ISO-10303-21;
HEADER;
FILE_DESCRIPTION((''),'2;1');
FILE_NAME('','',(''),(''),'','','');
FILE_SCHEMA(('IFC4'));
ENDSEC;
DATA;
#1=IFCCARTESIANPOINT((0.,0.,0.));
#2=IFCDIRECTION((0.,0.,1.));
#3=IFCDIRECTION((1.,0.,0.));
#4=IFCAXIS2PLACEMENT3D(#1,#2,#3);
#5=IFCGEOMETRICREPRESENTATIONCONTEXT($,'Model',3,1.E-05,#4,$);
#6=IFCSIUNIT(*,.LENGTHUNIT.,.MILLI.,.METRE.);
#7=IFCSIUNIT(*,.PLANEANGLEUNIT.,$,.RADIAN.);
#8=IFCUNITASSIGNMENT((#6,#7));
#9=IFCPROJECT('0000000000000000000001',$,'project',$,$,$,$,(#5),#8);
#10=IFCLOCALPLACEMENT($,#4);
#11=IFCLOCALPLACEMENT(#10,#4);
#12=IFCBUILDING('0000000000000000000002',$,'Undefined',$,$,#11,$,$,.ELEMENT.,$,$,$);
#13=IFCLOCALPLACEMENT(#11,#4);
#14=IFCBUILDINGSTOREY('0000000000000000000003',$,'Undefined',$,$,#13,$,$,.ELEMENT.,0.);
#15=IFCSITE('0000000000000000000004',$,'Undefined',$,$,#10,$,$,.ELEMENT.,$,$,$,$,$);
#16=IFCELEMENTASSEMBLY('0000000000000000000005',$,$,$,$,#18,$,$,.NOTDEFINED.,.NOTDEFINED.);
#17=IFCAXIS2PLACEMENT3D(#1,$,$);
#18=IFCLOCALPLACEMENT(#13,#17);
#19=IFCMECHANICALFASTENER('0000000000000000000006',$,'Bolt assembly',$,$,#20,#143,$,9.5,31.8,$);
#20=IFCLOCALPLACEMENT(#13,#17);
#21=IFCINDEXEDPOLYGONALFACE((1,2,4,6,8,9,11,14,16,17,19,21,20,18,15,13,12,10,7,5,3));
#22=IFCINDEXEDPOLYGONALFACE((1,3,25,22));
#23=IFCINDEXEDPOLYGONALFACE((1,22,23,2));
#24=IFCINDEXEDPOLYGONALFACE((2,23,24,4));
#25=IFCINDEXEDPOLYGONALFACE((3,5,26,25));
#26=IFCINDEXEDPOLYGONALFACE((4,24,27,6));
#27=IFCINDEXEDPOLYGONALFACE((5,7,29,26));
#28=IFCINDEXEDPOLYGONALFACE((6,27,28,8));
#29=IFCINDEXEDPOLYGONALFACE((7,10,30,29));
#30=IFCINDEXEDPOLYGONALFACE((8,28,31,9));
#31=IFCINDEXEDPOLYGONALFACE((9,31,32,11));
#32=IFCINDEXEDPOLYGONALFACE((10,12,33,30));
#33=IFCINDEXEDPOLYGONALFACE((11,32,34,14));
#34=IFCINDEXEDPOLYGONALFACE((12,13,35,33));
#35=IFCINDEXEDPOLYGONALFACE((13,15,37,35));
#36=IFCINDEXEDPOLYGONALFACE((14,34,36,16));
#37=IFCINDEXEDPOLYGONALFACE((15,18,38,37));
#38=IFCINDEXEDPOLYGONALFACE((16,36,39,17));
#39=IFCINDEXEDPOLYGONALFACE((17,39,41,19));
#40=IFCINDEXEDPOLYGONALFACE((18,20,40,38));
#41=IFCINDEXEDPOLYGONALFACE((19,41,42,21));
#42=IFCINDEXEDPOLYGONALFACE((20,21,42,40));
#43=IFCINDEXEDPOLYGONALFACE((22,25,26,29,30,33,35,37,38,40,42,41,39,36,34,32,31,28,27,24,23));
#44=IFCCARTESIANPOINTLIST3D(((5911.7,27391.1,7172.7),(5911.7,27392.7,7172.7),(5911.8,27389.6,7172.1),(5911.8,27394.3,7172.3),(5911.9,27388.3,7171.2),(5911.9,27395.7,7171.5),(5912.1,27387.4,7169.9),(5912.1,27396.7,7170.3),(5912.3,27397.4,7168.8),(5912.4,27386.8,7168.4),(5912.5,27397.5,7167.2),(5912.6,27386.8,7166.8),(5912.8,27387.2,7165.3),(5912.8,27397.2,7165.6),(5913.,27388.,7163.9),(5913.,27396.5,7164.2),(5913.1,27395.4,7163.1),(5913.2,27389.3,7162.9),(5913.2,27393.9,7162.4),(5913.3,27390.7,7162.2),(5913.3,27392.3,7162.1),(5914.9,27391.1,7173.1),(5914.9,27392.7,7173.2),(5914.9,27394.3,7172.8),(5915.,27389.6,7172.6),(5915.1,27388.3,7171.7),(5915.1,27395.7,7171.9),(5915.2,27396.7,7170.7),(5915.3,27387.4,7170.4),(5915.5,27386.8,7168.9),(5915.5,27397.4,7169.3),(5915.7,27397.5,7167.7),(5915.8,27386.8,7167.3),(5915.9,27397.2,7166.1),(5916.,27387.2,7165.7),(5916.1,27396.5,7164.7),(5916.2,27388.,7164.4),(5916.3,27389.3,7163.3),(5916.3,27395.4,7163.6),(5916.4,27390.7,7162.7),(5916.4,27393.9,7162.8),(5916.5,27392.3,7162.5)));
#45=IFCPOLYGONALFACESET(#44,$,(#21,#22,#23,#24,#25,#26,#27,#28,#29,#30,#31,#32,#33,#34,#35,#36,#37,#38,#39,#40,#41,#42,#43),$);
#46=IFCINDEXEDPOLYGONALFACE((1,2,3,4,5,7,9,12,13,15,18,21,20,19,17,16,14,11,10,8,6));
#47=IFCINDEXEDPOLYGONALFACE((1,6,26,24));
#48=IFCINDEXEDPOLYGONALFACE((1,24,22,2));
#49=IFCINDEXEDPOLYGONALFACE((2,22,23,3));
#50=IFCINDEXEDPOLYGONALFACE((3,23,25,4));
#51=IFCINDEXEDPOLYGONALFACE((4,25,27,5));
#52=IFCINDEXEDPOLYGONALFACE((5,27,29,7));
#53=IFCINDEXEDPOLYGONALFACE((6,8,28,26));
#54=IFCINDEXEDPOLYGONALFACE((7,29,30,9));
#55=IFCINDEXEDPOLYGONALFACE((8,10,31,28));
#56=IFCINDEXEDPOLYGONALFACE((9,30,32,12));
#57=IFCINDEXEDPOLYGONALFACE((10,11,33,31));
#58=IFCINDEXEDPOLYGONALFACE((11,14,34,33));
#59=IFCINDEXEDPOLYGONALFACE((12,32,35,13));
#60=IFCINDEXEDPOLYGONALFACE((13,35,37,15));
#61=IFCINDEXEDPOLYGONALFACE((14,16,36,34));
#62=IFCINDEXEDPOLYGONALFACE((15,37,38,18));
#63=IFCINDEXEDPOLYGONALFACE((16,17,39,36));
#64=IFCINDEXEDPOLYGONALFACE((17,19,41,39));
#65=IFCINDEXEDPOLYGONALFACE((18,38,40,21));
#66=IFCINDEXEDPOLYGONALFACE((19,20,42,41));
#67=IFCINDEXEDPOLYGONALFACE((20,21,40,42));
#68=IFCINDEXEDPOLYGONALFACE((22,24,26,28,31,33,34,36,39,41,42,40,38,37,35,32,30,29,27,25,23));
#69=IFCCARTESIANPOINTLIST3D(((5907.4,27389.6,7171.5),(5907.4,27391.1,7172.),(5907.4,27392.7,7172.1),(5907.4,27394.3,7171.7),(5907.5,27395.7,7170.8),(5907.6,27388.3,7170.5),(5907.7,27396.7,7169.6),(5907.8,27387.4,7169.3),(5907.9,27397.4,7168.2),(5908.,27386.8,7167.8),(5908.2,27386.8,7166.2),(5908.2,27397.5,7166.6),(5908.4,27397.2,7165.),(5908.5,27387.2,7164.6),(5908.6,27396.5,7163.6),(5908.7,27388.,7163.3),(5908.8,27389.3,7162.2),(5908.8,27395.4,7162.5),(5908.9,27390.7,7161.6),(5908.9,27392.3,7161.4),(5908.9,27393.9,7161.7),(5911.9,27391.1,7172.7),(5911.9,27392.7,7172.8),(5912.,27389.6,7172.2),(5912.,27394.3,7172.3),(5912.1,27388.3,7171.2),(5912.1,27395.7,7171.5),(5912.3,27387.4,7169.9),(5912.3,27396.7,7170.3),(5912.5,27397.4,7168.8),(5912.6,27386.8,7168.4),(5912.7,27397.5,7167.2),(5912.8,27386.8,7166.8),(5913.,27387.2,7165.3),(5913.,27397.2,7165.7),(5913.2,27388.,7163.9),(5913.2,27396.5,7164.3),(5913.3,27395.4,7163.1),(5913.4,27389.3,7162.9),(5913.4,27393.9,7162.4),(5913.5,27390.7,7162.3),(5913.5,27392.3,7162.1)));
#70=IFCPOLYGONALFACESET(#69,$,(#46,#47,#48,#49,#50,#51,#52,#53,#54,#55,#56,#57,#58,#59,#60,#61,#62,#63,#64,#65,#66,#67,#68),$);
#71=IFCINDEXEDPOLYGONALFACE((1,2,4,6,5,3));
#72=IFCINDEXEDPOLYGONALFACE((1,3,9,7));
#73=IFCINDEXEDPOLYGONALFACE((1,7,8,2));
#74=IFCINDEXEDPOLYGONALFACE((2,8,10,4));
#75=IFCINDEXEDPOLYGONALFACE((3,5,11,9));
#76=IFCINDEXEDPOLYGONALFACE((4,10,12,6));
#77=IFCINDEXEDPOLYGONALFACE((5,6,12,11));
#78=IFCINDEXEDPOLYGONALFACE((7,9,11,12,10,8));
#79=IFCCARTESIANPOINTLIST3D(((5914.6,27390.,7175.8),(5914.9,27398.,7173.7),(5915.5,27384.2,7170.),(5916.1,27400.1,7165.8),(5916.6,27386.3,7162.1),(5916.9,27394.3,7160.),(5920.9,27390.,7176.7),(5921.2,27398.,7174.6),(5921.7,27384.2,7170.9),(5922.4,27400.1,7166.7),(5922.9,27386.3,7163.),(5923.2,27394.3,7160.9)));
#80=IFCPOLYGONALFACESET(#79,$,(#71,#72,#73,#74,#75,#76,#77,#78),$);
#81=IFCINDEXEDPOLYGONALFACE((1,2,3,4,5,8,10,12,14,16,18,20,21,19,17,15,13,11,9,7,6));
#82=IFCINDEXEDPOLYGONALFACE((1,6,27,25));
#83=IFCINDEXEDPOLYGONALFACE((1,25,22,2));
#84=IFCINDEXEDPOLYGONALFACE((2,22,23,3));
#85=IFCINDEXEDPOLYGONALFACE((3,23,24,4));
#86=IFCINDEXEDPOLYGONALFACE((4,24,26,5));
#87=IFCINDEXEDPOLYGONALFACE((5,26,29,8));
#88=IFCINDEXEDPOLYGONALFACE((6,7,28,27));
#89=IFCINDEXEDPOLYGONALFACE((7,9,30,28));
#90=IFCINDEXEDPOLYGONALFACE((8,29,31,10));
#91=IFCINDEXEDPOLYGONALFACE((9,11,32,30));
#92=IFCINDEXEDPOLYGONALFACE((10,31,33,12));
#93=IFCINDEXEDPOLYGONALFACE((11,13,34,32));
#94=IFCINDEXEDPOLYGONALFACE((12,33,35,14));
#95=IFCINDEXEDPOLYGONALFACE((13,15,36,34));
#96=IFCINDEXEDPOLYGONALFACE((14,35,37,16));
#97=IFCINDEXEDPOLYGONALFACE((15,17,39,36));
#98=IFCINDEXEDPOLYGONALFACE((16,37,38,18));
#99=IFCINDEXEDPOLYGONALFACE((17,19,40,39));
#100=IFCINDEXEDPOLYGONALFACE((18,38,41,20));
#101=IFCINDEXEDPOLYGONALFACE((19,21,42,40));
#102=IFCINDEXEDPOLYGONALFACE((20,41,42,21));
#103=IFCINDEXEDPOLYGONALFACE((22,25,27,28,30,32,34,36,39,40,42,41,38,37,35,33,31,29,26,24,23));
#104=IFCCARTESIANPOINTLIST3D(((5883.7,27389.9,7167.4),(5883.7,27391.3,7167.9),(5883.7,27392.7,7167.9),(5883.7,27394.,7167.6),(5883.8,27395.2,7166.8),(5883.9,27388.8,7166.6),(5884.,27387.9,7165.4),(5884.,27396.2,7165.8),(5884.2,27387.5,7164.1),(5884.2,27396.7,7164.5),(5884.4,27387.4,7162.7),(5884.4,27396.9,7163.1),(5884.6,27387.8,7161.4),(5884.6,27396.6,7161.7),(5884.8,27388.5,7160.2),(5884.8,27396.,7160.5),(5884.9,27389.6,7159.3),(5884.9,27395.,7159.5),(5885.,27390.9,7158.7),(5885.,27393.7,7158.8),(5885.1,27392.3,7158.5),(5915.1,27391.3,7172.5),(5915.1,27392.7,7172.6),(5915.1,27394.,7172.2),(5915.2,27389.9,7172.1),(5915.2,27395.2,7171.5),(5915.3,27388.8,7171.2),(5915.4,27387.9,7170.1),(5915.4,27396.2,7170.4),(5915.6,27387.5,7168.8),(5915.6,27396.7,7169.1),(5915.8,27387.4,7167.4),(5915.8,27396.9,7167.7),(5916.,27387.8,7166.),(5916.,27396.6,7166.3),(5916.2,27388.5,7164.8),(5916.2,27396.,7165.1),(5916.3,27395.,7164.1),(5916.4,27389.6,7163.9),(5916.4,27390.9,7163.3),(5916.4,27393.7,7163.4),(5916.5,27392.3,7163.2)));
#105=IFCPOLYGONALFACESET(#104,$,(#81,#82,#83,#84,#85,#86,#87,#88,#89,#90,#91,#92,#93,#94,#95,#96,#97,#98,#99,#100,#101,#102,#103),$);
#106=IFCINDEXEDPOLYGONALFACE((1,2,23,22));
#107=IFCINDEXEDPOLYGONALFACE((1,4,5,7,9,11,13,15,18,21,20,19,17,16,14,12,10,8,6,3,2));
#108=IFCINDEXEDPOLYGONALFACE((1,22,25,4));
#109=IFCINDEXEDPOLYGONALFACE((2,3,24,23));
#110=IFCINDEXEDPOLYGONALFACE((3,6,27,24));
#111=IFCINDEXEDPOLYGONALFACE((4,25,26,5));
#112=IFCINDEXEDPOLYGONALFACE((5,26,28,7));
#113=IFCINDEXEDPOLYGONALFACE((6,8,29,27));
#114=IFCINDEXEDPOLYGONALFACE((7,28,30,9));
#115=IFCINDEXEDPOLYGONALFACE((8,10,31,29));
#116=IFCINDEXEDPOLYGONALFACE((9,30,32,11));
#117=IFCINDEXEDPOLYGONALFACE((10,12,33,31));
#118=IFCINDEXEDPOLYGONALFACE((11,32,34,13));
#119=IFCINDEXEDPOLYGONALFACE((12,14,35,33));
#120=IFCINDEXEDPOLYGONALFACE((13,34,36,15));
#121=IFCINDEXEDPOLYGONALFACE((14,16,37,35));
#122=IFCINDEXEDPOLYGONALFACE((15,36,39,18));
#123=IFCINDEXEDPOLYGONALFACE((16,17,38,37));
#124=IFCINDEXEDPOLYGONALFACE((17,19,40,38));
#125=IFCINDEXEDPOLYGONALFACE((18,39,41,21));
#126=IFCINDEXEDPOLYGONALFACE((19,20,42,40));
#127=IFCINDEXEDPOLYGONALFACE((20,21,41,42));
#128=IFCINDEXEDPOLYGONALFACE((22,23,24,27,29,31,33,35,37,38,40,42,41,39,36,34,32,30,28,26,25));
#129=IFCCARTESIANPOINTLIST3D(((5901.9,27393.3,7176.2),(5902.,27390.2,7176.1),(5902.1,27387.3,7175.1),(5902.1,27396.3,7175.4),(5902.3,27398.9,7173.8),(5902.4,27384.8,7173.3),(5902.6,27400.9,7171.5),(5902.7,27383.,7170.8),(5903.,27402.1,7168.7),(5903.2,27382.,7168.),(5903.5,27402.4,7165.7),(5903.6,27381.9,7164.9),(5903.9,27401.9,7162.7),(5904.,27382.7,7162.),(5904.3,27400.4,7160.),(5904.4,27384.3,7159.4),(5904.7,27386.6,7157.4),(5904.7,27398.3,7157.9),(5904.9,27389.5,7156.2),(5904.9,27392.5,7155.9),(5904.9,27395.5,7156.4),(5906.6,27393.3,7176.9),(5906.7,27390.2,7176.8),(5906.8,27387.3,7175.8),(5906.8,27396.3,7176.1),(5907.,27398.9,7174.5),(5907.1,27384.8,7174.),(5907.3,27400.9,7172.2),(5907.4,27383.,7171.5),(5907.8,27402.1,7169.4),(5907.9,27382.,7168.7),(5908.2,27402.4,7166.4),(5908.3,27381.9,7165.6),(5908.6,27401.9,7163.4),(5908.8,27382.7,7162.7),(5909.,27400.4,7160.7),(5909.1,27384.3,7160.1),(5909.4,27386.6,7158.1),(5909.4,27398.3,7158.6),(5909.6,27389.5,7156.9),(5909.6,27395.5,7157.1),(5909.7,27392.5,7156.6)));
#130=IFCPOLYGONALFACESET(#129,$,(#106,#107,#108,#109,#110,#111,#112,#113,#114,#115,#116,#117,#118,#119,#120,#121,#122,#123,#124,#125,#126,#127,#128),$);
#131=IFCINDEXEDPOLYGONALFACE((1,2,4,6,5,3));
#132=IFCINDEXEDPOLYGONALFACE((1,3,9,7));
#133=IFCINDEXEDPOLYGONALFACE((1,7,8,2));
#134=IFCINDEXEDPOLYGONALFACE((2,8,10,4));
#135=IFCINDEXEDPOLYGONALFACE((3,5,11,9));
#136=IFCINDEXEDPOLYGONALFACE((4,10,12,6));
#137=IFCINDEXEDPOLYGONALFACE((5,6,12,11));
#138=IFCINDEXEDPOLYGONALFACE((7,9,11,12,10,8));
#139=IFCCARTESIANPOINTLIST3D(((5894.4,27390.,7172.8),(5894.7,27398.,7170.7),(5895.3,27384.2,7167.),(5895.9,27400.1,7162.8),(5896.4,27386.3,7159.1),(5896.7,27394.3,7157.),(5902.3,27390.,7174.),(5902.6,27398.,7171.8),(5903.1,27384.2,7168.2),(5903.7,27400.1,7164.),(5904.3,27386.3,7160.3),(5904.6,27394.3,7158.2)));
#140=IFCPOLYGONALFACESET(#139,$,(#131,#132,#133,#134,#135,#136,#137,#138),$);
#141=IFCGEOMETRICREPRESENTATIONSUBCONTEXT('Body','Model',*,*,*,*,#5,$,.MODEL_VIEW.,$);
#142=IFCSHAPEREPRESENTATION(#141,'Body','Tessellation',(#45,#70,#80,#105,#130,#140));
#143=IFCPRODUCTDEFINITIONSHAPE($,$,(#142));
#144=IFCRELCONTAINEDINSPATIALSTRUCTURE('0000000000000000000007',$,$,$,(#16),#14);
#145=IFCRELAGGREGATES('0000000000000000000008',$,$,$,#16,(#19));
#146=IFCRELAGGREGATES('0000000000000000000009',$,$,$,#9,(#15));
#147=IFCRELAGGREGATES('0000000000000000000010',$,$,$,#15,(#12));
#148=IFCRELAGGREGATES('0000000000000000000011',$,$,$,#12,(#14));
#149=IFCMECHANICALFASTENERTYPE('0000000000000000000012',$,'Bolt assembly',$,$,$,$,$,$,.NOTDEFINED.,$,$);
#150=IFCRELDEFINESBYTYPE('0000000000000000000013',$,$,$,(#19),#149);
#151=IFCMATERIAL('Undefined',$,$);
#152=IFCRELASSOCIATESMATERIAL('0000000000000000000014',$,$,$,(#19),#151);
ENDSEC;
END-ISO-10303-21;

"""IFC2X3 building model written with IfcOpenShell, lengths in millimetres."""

from ifc_helpers import new_model, si_unit, frame, origin_with_axes, origin_2d_with_axis, place, context, subcontext, project, spatial, polyline, circle, outline, extrude, source, transform, mapped, material, type_object, element, aggregate, save


model = new_model("IFC2X3")

# Units and contexts
model_context = context("Model", 3, precision=1e-05, world=origin_with_axes())
body_context = subcontext(model_context, "Body", "Model", "MODEL_VIEW")
ifc_project = project(units=[si_unit("LENGTHUNIT", "METRE", prefix="MILLI"), si_unit("PLANEANGLEUNIT", "RADIAN")], contexts=[model_context])

# Site, building, storey
site_placement = place(None, origin_with_axes())
site = spatial("IfcSite", under=ifc_project, at=site_placement, Name="Undefined", CompositionType="ELEMENT")
building_placement = place(site_placement, origin_with_axes())
building = spatial("IfcBuilding", under=site, at=building_placement, Name="Undefined", CompositionType="ELEMENT")
storey_placement = place(building_placement, origin_with_axes())
storey = spatial("IfcBuildingStorey", under=building, at=storey_placement, Name="Undefined", CompositionType="ELEMENT", Elevation=0.0)

# Element assembly
assembly_1_placement = place(storey_placement, origin_with_axes())
assembly_1 = element("IfcElementAssembly", 1, at=assembly_1_placement, inside=storey, AssemblyPlace="NOTDEFINED", PredefinedType="NOTDEFINED")

# Shared definitions
ifc_material_1 = material(Name="Undefined")
mechanical_fastener_type = type_object("IfcMechanicalFastenerType", Name="Bolt assembly")

# Mechanical fastener
shared_shape_1 = source(origin_with_axes(), body_context, "Body", "SweptSolid", [
    extrude(circle(Radius=5.4, at=origin_2d_with_axis()), frame((0.0, -3.1, 0.0), z_axis=(0.0, 1.0, 0.0), x_axis=(1.0, 0.0, 0.0)), (0.0, 0.0, 1.0), 3.2),
    extrude(circle(Radius=5.4, at=origin_2d_with_axis()), frame((0.0, -0.1, 0.0), z_axis=(0.0, 1.0, 0.0), x_axis=(1.0, 0.0, 0.0)), (0.0, 0.0, 1.0), 4.6),
    extrude(outline(polyline([(7.1, -4.1), (7.1, 4.1), (0.0, 8.2), (-7.1, 4.1), (-7.1, -4.1), (0.0, -8.2), (7.1, -4.1)])), frame((0.0, -9.6, 0.0), z_axis=(0.0, 1.0, 0.0), x_axis=(1.0, 0.0, 0.0)), (0.0, 0.0, 1.0), 6.3),
    extrude(circle(Radius=4.8, at=origin_2d_with_axis()), frame((0.0, -3.2, 0.0), z_axis=(0.0, 1.0, 0.0), x_axis=(1.0, 0.0, 0.0)), (0.0, 0.0, 1.0), 31.8),
    extrude(circle(Radius=10.3, at=origin_2d_with_axis()), frame((0.0, 4.5, 0.0), z_axis=(0.0, 1.0, 0.0), x_axis=(1.0, 0.0, 0.0)), (0.0, 0.0, 1.0), 4.8),
    extrude(outline(polyline([(7.1, -4.1), (7.1, 4.1), (0.0, 8.2), (-7.1, 4.1), (-7.1, -4.1), (0.0, -8.2), (7.1, -4.1)])), frame((0.0, 9.3, 0.0), z_axis=(0.0, 1.0, 0.0), x_axis=(1.0, 0.0, 0.0)), (0.0, 0.0, 1.0), 7.9),
])
mechanical_fastener_1_placement = place(assembly_1_placement, frame((5912.6, 27392.1, 7167.4), z_axis=(0.103381, -0.707107, -0.699509), x_axis=(-0.103381, -0.707107, 0.699509)))
mechanical_fastener_1 = element("IfcMechanicalFastener", 2, at=mechanical_fastener_1_placement, type_object=mechanical_fastener_type, material=ifc_material_1, Name="Bolt assembly", NominalDiameter=9.5, NominalLength=31.8, context=body_context, shape_type="MappedRepresentation", body=[
    mapped(shared_shape_1, transform((0.0, 0.0, 0.0))),
])
aggregate(assembly_1, [mechanical_fastener_1])

save(model, "model.ifc")
